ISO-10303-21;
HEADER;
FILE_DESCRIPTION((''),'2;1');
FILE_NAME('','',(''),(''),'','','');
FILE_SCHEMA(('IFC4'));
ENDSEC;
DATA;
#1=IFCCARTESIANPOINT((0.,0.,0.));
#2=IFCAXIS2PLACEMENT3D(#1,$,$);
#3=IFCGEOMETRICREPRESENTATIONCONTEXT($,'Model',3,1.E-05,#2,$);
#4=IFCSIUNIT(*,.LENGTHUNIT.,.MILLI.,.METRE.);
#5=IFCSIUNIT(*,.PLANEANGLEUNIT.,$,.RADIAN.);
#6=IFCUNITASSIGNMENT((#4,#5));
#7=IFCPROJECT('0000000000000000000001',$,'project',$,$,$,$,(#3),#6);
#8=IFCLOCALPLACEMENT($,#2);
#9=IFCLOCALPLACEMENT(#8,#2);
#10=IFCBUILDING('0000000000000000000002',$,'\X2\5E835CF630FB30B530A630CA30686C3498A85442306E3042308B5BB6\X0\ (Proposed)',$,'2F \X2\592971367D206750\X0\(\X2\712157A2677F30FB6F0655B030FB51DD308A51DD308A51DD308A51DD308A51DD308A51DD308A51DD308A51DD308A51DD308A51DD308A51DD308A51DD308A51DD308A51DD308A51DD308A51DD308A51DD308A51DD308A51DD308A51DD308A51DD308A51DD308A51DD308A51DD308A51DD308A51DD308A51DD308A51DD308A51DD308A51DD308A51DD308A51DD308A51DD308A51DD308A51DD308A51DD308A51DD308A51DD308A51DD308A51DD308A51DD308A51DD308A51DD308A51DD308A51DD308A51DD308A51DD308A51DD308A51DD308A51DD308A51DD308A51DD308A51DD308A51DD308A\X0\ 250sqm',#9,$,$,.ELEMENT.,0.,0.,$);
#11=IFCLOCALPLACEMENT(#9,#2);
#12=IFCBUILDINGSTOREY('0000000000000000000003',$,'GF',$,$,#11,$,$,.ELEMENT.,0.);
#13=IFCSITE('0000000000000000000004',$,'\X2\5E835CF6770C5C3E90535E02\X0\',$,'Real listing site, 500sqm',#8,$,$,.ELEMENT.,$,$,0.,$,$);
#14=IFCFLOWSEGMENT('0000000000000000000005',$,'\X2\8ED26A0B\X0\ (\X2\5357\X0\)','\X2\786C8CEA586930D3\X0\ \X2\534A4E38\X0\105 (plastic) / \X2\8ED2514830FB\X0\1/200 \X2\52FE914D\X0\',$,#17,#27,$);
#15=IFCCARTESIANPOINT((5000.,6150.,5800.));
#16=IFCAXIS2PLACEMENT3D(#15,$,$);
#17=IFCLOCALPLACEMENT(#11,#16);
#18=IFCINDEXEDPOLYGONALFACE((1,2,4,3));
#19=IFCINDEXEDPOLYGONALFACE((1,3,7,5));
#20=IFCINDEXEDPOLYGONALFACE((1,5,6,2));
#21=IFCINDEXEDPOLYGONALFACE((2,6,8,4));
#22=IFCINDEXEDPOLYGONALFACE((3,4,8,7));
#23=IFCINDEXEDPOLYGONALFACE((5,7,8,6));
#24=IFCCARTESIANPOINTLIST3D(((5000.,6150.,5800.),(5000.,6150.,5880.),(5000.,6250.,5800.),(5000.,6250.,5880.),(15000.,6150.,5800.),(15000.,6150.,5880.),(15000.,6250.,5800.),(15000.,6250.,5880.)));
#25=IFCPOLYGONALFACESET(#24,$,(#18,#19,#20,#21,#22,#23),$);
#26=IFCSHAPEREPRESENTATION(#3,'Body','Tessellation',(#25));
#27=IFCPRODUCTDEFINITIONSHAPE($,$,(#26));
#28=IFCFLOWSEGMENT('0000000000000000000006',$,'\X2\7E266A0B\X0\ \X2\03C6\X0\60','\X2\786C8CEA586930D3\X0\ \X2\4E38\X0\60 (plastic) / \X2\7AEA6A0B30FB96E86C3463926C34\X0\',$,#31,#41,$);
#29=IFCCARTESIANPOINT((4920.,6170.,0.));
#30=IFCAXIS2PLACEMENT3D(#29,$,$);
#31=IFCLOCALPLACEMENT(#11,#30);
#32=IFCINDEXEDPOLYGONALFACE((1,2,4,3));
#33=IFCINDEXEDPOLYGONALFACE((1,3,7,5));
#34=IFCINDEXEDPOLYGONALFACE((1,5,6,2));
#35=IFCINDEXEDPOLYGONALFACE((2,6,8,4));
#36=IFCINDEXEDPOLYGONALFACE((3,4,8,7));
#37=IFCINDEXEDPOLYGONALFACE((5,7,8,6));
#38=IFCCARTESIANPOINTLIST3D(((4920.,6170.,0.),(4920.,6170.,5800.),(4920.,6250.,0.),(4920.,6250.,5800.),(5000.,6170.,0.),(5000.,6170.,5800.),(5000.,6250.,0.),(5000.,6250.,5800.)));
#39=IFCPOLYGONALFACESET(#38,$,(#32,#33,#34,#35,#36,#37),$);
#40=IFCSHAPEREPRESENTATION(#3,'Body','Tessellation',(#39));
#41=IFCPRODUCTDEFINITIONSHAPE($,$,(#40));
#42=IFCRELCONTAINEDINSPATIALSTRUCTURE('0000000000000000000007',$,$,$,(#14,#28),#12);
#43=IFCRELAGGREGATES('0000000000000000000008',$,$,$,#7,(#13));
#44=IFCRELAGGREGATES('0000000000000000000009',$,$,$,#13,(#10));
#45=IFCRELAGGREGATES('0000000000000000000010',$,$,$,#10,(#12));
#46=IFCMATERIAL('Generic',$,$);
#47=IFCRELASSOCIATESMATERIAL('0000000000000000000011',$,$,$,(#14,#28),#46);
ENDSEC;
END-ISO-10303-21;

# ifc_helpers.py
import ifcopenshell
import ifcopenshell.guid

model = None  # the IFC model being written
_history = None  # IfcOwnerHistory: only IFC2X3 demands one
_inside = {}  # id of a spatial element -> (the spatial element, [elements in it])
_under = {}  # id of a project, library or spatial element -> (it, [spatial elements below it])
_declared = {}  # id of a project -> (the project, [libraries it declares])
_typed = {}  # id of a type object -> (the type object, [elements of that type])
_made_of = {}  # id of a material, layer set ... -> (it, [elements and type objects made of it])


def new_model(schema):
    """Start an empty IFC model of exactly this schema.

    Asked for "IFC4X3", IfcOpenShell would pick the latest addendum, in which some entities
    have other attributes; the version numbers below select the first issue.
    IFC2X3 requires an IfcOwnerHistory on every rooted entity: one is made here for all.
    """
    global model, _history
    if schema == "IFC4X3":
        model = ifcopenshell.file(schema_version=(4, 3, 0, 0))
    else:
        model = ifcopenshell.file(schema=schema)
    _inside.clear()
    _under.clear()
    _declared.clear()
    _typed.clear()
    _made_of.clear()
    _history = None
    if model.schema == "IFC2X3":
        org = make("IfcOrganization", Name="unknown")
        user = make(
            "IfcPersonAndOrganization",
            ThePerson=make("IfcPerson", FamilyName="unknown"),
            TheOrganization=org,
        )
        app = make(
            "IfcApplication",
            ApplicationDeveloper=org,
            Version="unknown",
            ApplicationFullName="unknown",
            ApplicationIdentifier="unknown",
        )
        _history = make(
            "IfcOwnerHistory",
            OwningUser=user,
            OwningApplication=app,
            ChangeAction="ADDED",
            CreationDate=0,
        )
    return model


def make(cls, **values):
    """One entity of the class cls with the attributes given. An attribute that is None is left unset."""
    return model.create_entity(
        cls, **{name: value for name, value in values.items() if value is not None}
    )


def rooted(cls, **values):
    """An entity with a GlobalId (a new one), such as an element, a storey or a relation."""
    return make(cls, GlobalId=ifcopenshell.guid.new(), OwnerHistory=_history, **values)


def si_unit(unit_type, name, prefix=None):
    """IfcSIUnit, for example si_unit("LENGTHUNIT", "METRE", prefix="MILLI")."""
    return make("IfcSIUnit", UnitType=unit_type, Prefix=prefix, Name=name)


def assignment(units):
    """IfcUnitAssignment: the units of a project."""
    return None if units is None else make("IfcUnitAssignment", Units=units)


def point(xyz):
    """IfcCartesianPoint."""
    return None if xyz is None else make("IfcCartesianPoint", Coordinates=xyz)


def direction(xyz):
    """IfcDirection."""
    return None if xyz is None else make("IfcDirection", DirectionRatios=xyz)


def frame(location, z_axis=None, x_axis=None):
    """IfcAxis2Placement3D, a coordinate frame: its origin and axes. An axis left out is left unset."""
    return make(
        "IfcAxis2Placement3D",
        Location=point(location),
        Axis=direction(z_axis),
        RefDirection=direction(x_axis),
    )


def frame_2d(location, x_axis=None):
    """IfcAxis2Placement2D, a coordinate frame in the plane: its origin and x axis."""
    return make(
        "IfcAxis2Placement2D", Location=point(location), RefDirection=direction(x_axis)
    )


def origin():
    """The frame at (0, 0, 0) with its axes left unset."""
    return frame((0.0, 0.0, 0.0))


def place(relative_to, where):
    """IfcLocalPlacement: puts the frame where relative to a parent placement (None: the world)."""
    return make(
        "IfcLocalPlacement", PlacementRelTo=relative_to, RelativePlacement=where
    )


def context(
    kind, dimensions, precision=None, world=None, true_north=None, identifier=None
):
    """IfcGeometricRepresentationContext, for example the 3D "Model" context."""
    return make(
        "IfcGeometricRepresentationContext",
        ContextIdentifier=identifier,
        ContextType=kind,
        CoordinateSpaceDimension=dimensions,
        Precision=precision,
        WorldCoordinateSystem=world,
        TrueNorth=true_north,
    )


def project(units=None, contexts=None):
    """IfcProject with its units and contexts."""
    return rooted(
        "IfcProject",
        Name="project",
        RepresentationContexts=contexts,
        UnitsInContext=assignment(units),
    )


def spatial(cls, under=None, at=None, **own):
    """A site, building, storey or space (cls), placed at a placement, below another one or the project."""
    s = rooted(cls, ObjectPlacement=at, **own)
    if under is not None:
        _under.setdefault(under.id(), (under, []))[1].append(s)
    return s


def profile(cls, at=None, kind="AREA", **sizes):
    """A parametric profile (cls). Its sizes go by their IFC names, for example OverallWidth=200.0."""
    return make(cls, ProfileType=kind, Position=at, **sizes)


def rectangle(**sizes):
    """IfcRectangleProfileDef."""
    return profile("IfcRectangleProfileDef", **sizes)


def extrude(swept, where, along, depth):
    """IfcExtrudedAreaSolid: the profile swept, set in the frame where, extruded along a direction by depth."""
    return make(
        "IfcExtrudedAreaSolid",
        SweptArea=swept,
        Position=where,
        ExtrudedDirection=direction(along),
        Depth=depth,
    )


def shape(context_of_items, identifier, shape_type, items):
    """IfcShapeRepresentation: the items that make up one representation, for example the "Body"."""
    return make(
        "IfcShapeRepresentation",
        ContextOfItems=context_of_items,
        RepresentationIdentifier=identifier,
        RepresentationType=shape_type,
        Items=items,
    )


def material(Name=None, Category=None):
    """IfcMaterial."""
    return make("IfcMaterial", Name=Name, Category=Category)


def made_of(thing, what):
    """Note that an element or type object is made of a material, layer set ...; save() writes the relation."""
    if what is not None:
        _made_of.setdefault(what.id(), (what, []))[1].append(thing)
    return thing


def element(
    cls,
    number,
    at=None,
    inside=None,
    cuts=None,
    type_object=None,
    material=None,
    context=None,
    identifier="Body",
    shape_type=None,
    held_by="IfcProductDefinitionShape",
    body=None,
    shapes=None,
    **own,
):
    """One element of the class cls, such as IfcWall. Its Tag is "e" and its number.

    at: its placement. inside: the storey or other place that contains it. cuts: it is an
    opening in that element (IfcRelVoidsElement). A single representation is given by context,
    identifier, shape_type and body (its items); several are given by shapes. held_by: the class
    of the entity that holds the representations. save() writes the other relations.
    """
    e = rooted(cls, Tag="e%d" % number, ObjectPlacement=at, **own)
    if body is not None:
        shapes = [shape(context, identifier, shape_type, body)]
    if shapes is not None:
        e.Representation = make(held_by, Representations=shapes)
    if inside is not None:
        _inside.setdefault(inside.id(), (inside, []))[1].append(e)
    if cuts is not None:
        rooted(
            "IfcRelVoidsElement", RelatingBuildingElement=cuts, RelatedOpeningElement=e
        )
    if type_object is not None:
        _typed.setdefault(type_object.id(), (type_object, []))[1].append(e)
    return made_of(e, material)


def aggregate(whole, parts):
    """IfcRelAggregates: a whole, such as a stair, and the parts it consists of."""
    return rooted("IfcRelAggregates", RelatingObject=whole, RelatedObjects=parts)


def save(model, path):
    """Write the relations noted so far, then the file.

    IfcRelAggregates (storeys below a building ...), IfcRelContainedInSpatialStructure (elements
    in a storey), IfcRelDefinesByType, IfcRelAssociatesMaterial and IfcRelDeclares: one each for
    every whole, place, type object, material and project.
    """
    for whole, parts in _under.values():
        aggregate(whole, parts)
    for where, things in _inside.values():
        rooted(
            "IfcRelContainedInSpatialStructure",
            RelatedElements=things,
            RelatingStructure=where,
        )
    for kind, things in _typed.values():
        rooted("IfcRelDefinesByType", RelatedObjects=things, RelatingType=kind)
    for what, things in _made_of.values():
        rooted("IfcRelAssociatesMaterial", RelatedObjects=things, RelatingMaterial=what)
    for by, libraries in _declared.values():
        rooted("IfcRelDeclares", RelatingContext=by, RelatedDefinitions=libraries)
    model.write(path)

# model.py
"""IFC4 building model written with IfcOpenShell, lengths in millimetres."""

from ifc_helpers import new_model, si_unit, frame, frame_2d, origin, place, context, project, spatial, rectangle, extrude, material, element, save


model = new_model("IFC4")

# Units and contexts
model_context = context("Model", 3, precision=1e-05, world=origin())
ifc_project = project(units=[si_unit("LENGTHUNIT", "METRE", prefix="MILLI"), si_unit("PLANEANGLEUNIT", "RADIAN")], contexts=[model_context])

# Site, building, storey
site_placement = place(None, origin())
site = spatial("IfcSite", under=ifc_project, at=site_placement, Name="広島県尾道市", ObjectType="Real listing site, 500sqm", CompositionType="ELEMENT", RefElevation=0.0)
building_placement = place(site_placement, origin())
building = spatial("IfcBuilding", under=site, at=building_placement, Name="広島・サウナと水風呂のある家 (Proposed)", ObjectType="2F 天然素材(無垢板・漆喰・凝り凝り凝り凝り凝り凝り凝り凝り凝り凝り凝り凝り凝り凝り凝り凝り凝り凝り凝り凝り凝り凝り凝り凝り凝り凝り凝り凝り凝り凝り凝り凝り凝り凝り凝り凝り凝り凝り凝り凝り凝り凝り凝り凝り凝り凝り凝り凝り凝り凝り凝り凝り凝り凝り 250sqm", CompositionType="ELEMENT", ElevationOfRefHeight=0.0, ElevationOfTerrain=0.0)
storey_placement = place(building_placement, origin())
storey = spatial("IfcBuildingStorey", under=building, at=storey_placement, Name="GF", CompositionType="ELEMENT", Elevation=0.0)

# Flow segments
ifc_material_1 = material(Name="Generic")
flow_segment_1_placement = place(storey_placement, frame((5000.0, 6150.0, 5800.0)))
element("IfcFlowSegment", 1, at=flow_segment_1_placement, inside=storey, material=ifc_material_1, Name="軒樋 (南)", Description="硬質塩ビ 半丸105 (plastic) / 軒先・1/200 勾配", context=model_context, shape_type="SweptSolid", body=[
    extrude(rectangle(XDim=10000.0, YDim=100.0, at=frame_2d((5000.0, 50.0))), frame((5000.0, 6150.0, 5800.0)), (0.0, 0.0, 1.0), 80.0),
])
flow_segment_2_placement = place(storey_placement, frame((4920.0, 6170.0, 0.0)))
element("IfcFlowSegment", 2, at=flow_segment_2_placement, inside=storey, material=ifc_material_1, Name="縦樋 φ60", Description="硬質塩ビ 丸60 (plastic) / 竪樋・雨水排水", context=model_context, shape_type="SweptSolid", body=[
    extrude(rectangle(XDim=80.0, YDim=80.0, at=frame_2d((40.0, 40.0))), frame((4920.0, 6170.0, 0.0)), (0.0, 0.0, 1.0), 5800.0),
])

save(model, "model.ifc")
